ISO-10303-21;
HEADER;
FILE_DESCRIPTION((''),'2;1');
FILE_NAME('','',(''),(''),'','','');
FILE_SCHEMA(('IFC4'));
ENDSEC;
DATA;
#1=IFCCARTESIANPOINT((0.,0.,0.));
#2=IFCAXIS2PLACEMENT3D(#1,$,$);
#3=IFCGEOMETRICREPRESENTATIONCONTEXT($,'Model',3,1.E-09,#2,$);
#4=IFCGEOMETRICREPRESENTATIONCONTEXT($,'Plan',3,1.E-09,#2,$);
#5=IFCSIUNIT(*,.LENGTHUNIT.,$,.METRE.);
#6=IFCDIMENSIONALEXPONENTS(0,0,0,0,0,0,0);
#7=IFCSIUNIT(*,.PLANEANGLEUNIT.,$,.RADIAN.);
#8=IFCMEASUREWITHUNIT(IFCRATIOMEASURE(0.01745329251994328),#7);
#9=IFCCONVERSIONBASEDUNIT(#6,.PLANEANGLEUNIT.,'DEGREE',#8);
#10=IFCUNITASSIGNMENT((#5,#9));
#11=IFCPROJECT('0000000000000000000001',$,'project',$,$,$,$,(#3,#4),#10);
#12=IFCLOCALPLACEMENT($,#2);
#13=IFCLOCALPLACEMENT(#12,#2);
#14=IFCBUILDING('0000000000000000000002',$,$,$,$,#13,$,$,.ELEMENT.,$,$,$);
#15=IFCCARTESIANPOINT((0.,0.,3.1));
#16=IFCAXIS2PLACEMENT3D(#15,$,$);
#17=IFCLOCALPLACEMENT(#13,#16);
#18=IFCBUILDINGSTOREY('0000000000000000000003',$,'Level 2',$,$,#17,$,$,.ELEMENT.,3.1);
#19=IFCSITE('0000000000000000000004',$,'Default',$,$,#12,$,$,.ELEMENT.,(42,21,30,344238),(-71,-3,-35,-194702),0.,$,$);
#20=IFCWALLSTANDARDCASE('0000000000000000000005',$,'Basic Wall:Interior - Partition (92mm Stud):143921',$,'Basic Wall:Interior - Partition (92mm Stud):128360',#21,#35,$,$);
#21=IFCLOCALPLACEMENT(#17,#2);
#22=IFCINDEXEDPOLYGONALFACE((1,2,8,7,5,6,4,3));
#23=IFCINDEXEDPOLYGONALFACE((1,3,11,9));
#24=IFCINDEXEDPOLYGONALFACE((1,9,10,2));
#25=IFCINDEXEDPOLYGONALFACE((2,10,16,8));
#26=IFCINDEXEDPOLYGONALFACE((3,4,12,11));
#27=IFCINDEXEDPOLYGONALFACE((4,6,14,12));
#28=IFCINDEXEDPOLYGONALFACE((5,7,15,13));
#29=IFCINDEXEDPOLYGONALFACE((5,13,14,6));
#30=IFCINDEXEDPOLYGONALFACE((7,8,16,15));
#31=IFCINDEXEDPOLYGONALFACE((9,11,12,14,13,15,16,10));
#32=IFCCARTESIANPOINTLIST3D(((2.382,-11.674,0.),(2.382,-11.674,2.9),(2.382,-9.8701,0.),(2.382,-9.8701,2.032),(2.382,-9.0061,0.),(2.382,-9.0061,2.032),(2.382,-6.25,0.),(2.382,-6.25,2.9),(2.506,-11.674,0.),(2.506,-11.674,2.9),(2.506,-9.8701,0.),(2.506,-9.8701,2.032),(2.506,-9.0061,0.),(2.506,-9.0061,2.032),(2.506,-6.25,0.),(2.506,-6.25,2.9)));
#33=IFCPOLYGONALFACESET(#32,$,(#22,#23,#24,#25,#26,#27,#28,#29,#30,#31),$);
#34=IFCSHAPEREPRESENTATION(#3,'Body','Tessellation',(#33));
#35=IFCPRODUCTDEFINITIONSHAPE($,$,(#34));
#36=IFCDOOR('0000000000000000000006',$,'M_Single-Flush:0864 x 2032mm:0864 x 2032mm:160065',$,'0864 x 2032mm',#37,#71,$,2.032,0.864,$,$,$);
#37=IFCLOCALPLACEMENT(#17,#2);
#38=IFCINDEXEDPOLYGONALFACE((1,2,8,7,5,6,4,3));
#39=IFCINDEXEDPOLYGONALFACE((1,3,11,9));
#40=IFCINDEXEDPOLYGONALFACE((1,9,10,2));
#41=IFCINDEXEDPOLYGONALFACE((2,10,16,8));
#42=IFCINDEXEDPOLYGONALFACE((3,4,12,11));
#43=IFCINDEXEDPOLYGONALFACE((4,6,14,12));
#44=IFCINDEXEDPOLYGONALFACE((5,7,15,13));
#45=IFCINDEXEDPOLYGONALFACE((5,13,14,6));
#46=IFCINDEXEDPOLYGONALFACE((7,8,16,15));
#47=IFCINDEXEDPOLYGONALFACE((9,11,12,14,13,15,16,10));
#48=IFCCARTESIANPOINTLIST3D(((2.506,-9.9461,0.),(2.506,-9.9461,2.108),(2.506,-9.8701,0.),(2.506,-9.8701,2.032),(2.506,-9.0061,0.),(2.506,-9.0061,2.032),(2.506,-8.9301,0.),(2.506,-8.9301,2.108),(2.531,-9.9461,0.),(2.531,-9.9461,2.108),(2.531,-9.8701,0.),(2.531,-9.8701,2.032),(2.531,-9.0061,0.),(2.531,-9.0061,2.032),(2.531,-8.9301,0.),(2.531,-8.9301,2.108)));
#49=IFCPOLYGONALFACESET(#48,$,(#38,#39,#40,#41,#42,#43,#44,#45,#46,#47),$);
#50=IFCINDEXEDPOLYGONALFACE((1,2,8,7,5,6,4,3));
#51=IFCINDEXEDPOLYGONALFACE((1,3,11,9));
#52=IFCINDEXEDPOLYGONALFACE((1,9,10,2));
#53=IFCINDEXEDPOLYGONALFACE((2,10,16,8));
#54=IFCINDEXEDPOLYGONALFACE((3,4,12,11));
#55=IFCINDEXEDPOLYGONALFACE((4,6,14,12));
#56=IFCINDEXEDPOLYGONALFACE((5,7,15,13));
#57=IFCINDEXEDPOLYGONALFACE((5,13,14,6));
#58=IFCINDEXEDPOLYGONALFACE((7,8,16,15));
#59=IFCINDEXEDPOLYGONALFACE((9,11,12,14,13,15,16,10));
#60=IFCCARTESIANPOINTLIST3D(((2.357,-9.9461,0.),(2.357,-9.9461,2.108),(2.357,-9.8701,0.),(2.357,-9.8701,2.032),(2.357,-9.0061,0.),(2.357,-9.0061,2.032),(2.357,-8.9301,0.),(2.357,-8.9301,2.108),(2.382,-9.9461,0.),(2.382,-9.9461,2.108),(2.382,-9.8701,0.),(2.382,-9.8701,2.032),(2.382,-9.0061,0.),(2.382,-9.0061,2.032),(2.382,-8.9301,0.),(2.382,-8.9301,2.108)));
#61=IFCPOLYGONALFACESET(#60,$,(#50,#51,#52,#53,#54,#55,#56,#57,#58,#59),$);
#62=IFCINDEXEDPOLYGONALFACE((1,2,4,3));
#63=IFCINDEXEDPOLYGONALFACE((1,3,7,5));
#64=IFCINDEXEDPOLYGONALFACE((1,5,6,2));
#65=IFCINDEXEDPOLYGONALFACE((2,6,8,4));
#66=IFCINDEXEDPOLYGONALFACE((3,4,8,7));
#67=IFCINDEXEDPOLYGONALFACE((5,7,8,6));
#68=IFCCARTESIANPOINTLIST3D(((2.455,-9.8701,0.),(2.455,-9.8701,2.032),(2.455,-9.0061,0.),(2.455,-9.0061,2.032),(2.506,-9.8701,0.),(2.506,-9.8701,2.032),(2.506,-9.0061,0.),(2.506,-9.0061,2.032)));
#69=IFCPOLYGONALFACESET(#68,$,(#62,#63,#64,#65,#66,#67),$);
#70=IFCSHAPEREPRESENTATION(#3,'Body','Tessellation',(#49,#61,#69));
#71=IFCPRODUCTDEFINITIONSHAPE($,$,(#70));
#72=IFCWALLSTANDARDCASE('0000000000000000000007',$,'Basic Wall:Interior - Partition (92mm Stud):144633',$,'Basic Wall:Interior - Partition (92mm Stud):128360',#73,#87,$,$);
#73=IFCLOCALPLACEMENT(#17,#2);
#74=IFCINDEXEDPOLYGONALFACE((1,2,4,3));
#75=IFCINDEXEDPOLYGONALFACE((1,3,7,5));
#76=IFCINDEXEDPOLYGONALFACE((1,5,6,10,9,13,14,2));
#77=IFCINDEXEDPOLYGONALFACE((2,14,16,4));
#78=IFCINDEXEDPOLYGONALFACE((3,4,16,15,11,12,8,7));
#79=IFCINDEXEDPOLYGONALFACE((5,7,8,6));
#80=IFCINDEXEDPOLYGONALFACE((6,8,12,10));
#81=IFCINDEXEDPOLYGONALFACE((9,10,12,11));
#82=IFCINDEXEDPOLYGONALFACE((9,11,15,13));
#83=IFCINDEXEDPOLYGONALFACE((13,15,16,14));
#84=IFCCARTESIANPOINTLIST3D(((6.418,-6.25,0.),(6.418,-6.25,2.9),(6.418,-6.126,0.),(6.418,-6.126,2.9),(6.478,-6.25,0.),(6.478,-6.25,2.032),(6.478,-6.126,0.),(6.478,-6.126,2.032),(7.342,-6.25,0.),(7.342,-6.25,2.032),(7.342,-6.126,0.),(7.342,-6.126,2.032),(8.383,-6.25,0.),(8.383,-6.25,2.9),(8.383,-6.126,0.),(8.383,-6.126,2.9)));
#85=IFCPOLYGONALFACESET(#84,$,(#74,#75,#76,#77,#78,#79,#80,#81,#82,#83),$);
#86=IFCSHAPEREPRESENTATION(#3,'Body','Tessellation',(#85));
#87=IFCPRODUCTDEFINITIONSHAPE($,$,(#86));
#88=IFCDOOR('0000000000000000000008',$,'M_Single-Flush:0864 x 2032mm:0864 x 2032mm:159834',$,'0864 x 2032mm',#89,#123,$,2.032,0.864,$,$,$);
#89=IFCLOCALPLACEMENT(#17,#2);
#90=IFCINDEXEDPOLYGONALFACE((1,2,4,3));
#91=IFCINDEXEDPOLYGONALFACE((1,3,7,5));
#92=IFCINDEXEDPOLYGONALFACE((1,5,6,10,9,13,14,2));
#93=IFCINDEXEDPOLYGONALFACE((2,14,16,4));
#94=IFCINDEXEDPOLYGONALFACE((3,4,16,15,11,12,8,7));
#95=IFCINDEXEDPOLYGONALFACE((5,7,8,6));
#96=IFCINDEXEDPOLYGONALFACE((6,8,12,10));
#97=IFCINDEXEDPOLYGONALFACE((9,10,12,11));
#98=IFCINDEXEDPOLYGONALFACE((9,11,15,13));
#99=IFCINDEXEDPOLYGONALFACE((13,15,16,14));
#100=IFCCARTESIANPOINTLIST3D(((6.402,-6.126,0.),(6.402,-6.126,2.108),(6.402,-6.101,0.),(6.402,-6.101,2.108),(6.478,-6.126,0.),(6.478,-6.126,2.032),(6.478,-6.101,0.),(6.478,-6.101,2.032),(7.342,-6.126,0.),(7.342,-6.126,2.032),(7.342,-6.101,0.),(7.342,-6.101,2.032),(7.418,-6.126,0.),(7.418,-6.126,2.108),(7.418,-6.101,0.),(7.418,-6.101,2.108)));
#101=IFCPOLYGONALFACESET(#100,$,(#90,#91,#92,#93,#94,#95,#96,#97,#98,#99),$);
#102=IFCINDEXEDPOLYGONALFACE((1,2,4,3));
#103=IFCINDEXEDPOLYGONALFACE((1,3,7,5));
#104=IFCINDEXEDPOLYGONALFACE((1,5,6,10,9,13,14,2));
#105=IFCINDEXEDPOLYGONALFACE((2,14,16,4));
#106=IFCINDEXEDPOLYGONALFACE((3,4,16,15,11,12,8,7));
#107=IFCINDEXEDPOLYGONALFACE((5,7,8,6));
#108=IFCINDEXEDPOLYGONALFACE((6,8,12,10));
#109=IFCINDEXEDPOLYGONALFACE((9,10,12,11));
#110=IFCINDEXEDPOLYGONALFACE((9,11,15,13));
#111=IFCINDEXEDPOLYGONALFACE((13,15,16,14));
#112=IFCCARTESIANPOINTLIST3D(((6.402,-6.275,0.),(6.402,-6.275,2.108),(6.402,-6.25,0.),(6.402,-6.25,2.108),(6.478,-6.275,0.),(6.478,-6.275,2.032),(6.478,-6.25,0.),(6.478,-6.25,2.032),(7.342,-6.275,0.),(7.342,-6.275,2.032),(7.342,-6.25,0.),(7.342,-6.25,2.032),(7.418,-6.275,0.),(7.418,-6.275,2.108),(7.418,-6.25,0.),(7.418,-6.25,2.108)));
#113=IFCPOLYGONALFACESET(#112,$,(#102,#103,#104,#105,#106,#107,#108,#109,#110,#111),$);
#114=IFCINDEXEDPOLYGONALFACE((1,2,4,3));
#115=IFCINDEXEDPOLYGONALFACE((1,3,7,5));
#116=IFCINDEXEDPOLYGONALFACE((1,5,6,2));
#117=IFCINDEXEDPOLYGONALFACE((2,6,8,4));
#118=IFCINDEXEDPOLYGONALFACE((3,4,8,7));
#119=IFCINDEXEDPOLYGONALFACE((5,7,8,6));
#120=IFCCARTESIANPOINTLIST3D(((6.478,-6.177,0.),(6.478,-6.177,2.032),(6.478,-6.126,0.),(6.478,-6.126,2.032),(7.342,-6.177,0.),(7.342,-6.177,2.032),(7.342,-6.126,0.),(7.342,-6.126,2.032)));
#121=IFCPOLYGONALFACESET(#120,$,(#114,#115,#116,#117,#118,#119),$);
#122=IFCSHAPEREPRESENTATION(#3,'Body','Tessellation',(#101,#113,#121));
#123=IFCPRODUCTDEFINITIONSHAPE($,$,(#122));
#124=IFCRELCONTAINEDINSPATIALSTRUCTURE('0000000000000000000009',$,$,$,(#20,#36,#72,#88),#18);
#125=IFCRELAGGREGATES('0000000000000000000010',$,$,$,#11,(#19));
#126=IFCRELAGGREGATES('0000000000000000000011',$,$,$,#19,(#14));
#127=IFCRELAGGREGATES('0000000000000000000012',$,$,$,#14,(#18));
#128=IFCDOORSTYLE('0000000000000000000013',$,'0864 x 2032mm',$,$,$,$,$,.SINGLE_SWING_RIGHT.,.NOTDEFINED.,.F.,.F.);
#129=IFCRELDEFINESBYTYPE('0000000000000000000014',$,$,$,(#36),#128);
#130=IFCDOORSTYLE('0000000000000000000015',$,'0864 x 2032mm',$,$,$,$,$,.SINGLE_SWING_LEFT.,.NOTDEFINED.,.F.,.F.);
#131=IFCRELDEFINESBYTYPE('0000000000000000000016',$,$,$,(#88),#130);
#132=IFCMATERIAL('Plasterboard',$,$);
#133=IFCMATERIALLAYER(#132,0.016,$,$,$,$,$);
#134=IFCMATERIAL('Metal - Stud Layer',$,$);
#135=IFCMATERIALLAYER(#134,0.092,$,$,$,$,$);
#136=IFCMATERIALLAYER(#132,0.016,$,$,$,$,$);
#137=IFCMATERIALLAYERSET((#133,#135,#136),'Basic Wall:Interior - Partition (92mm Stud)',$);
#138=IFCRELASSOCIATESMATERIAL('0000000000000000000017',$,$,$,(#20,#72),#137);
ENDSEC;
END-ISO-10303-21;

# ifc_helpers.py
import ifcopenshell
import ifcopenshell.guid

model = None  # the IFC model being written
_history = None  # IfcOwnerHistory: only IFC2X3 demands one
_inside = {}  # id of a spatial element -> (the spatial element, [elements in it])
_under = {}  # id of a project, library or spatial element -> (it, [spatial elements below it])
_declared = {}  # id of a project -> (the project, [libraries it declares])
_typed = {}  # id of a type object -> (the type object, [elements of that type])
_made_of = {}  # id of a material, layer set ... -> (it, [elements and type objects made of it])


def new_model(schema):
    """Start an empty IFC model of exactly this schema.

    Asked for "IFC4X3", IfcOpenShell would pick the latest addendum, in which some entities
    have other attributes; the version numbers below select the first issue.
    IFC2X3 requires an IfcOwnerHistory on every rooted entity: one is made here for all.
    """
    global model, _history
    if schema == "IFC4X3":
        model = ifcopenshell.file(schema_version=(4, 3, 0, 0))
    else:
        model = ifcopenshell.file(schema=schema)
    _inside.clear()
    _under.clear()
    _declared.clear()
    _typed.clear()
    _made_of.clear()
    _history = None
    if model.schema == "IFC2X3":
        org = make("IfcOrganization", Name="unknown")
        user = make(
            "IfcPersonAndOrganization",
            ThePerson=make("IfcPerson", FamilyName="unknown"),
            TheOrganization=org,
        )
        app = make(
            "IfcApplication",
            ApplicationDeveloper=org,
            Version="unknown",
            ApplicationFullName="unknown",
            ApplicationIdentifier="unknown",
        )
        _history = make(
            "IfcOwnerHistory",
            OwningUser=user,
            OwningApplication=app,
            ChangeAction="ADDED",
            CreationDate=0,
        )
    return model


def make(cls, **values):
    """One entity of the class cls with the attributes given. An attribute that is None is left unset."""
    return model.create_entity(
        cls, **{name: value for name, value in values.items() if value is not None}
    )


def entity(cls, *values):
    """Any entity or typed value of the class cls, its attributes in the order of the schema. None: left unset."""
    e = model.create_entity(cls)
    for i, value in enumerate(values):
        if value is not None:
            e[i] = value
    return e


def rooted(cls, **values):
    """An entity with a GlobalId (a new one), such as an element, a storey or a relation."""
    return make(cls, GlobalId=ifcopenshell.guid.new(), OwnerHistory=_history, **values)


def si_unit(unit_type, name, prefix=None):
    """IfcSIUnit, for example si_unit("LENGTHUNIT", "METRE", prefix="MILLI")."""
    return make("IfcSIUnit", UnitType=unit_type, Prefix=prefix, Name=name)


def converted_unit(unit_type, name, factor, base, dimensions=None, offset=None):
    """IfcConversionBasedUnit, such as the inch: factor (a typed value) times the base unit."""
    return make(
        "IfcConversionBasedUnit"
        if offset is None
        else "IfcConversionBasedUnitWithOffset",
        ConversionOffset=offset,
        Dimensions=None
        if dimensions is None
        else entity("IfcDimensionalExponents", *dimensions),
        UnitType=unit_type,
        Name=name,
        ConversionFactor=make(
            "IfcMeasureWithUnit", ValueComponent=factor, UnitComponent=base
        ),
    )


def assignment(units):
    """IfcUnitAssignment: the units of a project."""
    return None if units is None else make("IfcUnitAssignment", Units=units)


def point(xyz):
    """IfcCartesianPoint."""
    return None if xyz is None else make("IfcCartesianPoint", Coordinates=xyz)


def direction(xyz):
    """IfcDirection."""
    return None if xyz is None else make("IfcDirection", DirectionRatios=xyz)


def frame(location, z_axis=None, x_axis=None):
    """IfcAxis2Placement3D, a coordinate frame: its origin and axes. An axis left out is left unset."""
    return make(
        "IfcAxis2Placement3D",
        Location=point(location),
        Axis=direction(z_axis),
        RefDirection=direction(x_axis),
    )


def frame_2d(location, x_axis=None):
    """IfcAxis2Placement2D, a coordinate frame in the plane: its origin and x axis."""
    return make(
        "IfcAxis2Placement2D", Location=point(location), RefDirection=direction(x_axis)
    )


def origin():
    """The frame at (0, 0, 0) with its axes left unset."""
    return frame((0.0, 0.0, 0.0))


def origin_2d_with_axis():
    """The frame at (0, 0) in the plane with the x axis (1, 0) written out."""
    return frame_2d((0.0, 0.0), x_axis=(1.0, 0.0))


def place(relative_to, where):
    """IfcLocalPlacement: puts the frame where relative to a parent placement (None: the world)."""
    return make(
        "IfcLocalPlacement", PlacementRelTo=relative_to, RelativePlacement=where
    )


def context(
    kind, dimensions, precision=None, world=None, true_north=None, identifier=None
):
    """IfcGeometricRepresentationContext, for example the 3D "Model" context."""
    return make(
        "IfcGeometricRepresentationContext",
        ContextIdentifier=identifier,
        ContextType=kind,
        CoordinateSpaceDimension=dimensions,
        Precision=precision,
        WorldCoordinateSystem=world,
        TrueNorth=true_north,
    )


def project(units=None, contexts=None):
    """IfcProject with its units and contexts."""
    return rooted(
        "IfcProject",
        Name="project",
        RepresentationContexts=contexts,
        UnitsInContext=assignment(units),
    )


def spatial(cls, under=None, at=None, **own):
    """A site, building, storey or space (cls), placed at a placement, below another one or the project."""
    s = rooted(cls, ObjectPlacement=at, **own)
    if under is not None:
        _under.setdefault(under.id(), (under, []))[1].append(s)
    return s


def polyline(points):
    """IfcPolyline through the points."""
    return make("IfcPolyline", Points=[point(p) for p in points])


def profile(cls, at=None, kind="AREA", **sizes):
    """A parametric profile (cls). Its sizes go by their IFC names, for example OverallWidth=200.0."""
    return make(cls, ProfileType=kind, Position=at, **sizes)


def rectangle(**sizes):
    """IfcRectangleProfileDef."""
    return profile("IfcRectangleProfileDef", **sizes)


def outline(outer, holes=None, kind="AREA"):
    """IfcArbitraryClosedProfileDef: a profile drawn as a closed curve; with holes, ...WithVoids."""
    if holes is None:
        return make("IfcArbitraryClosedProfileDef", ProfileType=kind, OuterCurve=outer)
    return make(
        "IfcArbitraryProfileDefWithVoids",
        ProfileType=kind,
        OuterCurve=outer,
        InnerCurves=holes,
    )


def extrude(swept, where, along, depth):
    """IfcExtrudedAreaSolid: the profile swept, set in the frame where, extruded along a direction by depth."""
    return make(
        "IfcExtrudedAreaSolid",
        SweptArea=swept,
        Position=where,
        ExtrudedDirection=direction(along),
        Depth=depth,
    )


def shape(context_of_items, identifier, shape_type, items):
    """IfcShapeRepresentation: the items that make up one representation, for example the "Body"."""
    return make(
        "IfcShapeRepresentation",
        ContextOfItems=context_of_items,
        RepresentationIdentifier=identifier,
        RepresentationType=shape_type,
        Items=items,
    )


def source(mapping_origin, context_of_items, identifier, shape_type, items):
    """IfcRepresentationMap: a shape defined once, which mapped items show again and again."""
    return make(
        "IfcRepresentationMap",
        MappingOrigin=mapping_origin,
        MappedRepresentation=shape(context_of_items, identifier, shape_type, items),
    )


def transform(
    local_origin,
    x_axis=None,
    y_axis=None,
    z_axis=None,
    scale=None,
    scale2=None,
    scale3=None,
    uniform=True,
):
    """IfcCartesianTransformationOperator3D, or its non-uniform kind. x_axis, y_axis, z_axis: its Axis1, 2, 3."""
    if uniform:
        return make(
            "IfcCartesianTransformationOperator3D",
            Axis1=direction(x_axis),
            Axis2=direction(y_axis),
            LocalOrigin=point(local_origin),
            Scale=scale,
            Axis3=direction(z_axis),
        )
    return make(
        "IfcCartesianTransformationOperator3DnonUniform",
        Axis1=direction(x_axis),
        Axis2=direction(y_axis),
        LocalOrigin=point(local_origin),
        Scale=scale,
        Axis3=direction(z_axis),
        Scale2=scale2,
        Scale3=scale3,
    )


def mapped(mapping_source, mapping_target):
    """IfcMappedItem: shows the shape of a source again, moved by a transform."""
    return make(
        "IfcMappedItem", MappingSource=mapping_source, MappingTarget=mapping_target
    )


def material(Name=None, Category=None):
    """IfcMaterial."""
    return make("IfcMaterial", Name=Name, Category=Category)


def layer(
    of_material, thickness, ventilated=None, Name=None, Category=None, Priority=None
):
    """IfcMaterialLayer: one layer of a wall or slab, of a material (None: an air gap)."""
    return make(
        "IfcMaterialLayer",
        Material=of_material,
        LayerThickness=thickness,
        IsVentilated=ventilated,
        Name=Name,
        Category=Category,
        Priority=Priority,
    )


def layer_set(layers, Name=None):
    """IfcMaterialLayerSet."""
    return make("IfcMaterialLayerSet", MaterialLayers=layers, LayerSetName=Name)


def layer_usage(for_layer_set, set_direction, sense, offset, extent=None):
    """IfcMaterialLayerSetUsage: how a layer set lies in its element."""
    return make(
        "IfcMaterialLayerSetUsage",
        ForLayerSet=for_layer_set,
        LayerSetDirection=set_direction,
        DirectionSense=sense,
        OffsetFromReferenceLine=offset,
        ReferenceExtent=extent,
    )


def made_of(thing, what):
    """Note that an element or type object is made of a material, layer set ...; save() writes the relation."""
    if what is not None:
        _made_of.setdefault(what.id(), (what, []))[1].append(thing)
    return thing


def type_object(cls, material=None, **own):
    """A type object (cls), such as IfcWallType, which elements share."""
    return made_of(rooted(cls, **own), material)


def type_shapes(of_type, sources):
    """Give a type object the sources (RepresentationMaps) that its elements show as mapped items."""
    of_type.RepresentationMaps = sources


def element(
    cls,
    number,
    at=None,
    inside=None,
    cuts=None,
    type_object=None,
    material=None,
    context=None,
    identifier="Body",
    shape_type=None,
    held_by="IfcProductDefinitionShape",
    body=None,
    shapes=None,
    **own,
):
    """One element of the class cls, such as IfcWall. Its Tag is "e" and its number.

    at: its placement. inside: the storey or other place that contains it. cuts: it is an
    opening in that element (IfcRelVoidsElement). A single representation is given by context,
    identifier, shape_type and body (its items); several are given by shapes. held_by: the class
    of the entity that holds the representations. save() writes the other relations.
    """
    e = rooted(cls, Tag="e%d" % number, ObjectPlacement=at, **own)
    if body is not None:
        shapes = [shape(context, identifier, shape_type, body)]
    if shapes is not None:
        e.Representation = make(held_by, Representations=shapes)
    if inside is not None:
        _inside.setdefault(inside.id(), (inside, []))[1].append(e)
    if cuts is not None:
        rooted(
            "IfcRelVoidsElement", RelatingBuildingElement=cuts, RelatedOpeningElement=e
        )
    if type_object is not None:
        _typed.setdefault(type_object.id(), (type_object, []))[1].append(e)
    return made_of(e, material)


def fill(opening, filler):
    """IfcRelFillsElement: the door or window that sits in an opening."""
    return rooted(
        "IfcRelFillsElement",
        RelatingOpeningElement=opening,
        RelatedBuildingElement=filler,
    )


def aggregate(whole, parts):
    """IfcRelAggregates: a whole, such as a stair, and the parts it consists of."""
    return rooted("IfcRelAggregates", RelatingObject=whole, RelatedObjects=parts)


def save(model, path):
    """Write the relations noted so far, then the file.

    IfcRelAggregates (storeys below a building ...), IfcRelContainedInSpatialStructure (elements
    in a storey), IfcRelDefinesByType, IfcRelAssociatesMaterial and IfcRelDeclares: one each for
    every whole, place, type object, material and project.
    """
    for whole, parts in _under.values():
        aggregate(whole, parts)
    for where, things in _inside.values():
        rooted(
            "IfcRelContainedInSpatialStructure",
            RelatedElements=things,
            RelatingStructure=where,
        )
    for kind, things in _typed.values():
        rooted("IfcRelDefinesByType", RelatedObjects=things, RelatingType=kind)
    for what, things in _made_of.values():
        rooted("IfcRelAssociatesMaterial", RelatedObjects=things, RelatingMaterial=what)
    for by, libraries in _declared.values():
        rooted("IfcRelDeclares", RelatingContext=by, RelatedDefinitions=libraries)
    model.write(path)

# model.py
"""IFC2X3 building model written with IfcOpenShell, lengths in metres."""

from ifc_helpers import new_model, entity, si_unit, converted_unit, frame, frame_2d, origin, origin_2d_with_axis, place, context, project, spatial, polyline, rectangle, outline, extrude, source, transform, mapped, material, layer, layer_set, layer_usage, type_object, type_shapes, element, fill, save


model = new_model("IFC2X3")

# Units and contexts
model_context = context("Model", 3, precision=1e-09, world=origin())
plan_context = context("Plan", 3, precision=1e-09, world=origin())
ifc_project = project(units=[si_unit("LENGTHUNIT", "METRE"), converted_unit("PLANEANGLEUNIT", "DEGREE", entity("IfcRatioMeasure", 0.01745329251994328), si_unit("PLANEANGLEUNIT", "RADIAN"), dimensions=[0, 0, 0, 0, 0, 0, 0])], contexts=[model_context, plan_context])

# Site, building, storey
site_placement = place(None, origin())
site = spatial("IfcSite", under=ifc_project, at=site_placement, Name="Default", CompositionType="ELEMENT", RefLatitude=(42, 21, 30, 344238), RefLongitude=(-71, -3, -35, -194702), RefElevation=0.0)
building_placement = place(site_placement, origin())
building = spatial("IfcBuilding", under=site, at=building_placement, CompositionType="ELEMENT")
storey_placement = place(building_placement, frame((0.0, 0.0, 3.1)))
storey = spatial("IfcBuildingStorey", under=building, at=storey_placement, Name="Level 2", CompositionType="ELEMENT", Elevation=3.1)

# Shared definitions
ifc_material_1 = material(Name="Metal - Stud Layer")
ifc_material_2 = material(Name="Plasterboard")

# Walls, openings, doors
ifc_layer_1 = layer(ifc_material_2, 0.016)
ifc_layer_2 = layer(ifc_material_1, 0.092)
ifc_layer_3 = layer(ifc_material_2, 0.016)
ifc_layer_set_1 = layer_set([ifc_layer_1, ifc_layer_2, ifc_layer_3], Name="Basic Wall:Interior - Partition (92mm Stud)")
ifc_layer_usage_1 = layer_usage(ifc_layer_set_1, "AXIS2", "NEGATIVE", 0.062)
wall_1_placement = place(storey_placement, frame((2.444, -6.25, 0.0), z_axis=(0.0, 0.0, 1.0), x_axis=(0.0, -1.0, 0.0)))
wall_1 = element("IfcWallStandardCase", 1, at=wall_1_placement, inside=storey, material=ifc_layer_usage_1, Name="Basic Wall:Interior - Partition (92mm Stud):143921", ObjectType="Basic Wall:Interior - Partition (92mm Stud):128360", context=model_context, shape_type="SweptSolid", body=[
    extrude(rectangle(XDim=5.424, YDim=0.124, at=frame_2d((2.712, 0.0), x_axis=(-1.0, 0.0))), origin(), (0.0, 0.0, 1.0), 2.9),
])
opening_1_placement = place(wall_1_placement, frame((2.7561, -0.062, 0.0)))
opening_1 = element("IfcOpeningElement", 2, at=opening_1_placement, cuts=wall_1, ObjectType="Opening", context=model_context, shape_type="SweptSolid", body=[
    extrude(rectangle(XDim=0.864, YDim=2.032, at=frame_2d((1.016, 0.432), x_axis=(0.0, 1.0))), frame((0.0, 0.0, 0.0), z_axis=(0.0, 1.0, 0.0), x_axis=(0.0, 0.0, 1.0)), (0.0, 0.0, 1.0), 0.124),
])
door_style_1 = type_object("IfcDoorStyle", Name="0864 x 2032mm", ConstructionType="NOTDEFINED", OperationType="SINGLE_SWING_RIGHT", ParameterTakesPrecedence=False, Sizeable=False)
shared_shape_1 = source(origin(), model_context, "Body", "SweptSolid", [
    extrude(outline(polyline([(-0.508, -1.073), (0.508, -1.073), (0.508, 1.035), (0.432, 1.035), (0.432, -0.997), (-0.432, -0.997), (-0.432, 1.035), (-0.508, 1.035), (-0.508, -1.073)])), frame((0.432, 0.124, 1.035), z_axis=(0.0, 1.0, 0.0), x_axis=(1.0, 0.0, 0.0)), (0.0, 0.0, 1.0), 0.025),
    extrude(outline(polyline([(-1.073, -0.508), (1.035, -0.508), (1.035, -0.432), (-0.997, -0.432), (-0.997, 0.432), (1.035, 0.432), (1.035, 0.508), (-1.073, 0.508), (-1.073, -0.508)])), frame((0.432, -0.025, 1.035), z_axis=(0.0, 1.0, 0.0), x_axis=(0.0, 0.0, -1.0)), (0.0, 0.0, 1.0), 0.025),
    extrude(rectangle(XDim=0.051, YDim=0.864, at=origin_2d_with_axis()), frame((0.432, 0.0985, 0.0), z_axis=(0.0, 0.0, 1.0), x_axis=(0.0, 1.0, 0.0)), (0.0, 0.0, 1.0), 2.032),
])
type_shapes(door_style_1, [shared_shape_1])
door_1_placement = place(opening_1_placement, origin())
door_1 = element("IfcDoor", 3, at=door_1_placement, inside=storey, type_object=door_style_1, Name="M_Single-Flush:0864 x 2032mm:0864 x 2032mm:160065", ObjectType="0864 x 2032mm", OverallHeight=2.032, OverallWidth=0.864, context=model_context, shape_type="MappedRepresentation", body=[
    mapped(shared_shape_1, transform((0.0, 0.0, 0.0), scale=1.0)),
])
fill(opening_1, door_1)
ifc_layer_usage_2 = layer_usage(ifc_layer_set_1, "AXIS2", "NEGATIVE", 0.062)
wall_2_placement = place(storey_placement, frame((6.418, -6.188, 0.0)))
wall_2 = element("IfcWallStandardCase", 4, at=wall_2_placement, inside=storey, material=ifc_layer_usage_2, Name="Basic Wall:Interior - Partition (92mm Stud):144633", ObjectType="Basic Wall:Interior - Partition (92mm Stud):128360", context=model_context, shape_type="SweptSolid", body=[
    extrude(rectangle(XDim=1.965, YDim=0.124, at=frame_2d((0.9825, 0.0), x_axis=(-1.0, 0.0))), origin(), (0.0, 0.0, 1.0), 2.9),
])
opening_2_placement = place(wall_2_placement, frame((0.06, -0.062, 0.0)))
opening_2 = element("IfcOpeningElement", 5, at=opening_2_placement, cuts=wall_2, ObjectType="Opening", context=model_context, shape_type="SweptSolid", body=[
    extrude(rectangle(XDim=0.864, YDim=2.032, at=frame_2d((1.016, 0.432), x_axis=(0.0, -1.0))), frame((0.0, 0.0, 0.0), z_axis=(0.0, 1.0, 0.0), x_axis=(0.0, 0.0, 1.0)), (0.0, 0.0, 1.0), 0.124),
])
door_style_2 = type_object("IfcDoorStyle", Name="0864 x 2032mm", ConstructionType="NOTDEFINED", OperationType="SINGLE_SWING_LEFT", ParameterTakesPrecedence=False, Sizeable=False)
shared_shape_2 = source(origin(), model_context, "Body", "SweptSolid", [
    extrude(outline(polyline([(-0.508, -1.073), (0.508, -1.073), (0.508, 1.035), (0.432, 1.035), (0.432, -0.997), (-0.432, -0.997), (-0.432, 1.035), (-0.508, 1.035), (-0.508, -1.073)])), frame((0.432, 0.149, 1.035), z_axis=(0.0, -1.0, 0.0), x_axis=(-1.0, 0.0, 0.0)), (0.0, 0.0, 1.0), 0.025),
    extrude(outline(polyline([(-1.073, -0.508), (1.035, -0.508), (1.035, -0.432), (-0.997, -0.432), (-0.997, 0.432), (1.035, 0.432), (1.035, 0.508), (-1.073, 0.508), (-1.073, -0.508)])), frame((0.432, 0.0, 1.035), z_axis=(0.0, -1.0, 0.0), x_axis=(0.0, 0.0, -1.0)), (0.0, 0.0, 1.0), 0.025),
    extrude(rectangle(XDim=0.864, YDim=0.051, at=origin_2d_with_axis()), frame((0.432, 0.0985, 0.0)), (0.0, 0.0, 1.0), 2.032),
])
type_shapes(door_style_2, [shared_shape_2])
door_2_placement = place(opening_2_placement, origin())
door_2 = element("IfcDoor", 6, at=door_2_placement, inside=storey, type_object=door_style_2, Name="M_Single-Flush:0864 x 2032mm:0864 x 2032mm:159834", ObjectType="0864 x 2032mm", OverallHeight=2.032, OverallWidth=0.864, context=model_context, shape_type="MappedRepresentation", body=[
    mapped(shared_shape_2, transform((0.0, 0.0, 0.0), scale=1.0)),
])
fill(opening_2, door_2)

save(model, "model.ifc")
